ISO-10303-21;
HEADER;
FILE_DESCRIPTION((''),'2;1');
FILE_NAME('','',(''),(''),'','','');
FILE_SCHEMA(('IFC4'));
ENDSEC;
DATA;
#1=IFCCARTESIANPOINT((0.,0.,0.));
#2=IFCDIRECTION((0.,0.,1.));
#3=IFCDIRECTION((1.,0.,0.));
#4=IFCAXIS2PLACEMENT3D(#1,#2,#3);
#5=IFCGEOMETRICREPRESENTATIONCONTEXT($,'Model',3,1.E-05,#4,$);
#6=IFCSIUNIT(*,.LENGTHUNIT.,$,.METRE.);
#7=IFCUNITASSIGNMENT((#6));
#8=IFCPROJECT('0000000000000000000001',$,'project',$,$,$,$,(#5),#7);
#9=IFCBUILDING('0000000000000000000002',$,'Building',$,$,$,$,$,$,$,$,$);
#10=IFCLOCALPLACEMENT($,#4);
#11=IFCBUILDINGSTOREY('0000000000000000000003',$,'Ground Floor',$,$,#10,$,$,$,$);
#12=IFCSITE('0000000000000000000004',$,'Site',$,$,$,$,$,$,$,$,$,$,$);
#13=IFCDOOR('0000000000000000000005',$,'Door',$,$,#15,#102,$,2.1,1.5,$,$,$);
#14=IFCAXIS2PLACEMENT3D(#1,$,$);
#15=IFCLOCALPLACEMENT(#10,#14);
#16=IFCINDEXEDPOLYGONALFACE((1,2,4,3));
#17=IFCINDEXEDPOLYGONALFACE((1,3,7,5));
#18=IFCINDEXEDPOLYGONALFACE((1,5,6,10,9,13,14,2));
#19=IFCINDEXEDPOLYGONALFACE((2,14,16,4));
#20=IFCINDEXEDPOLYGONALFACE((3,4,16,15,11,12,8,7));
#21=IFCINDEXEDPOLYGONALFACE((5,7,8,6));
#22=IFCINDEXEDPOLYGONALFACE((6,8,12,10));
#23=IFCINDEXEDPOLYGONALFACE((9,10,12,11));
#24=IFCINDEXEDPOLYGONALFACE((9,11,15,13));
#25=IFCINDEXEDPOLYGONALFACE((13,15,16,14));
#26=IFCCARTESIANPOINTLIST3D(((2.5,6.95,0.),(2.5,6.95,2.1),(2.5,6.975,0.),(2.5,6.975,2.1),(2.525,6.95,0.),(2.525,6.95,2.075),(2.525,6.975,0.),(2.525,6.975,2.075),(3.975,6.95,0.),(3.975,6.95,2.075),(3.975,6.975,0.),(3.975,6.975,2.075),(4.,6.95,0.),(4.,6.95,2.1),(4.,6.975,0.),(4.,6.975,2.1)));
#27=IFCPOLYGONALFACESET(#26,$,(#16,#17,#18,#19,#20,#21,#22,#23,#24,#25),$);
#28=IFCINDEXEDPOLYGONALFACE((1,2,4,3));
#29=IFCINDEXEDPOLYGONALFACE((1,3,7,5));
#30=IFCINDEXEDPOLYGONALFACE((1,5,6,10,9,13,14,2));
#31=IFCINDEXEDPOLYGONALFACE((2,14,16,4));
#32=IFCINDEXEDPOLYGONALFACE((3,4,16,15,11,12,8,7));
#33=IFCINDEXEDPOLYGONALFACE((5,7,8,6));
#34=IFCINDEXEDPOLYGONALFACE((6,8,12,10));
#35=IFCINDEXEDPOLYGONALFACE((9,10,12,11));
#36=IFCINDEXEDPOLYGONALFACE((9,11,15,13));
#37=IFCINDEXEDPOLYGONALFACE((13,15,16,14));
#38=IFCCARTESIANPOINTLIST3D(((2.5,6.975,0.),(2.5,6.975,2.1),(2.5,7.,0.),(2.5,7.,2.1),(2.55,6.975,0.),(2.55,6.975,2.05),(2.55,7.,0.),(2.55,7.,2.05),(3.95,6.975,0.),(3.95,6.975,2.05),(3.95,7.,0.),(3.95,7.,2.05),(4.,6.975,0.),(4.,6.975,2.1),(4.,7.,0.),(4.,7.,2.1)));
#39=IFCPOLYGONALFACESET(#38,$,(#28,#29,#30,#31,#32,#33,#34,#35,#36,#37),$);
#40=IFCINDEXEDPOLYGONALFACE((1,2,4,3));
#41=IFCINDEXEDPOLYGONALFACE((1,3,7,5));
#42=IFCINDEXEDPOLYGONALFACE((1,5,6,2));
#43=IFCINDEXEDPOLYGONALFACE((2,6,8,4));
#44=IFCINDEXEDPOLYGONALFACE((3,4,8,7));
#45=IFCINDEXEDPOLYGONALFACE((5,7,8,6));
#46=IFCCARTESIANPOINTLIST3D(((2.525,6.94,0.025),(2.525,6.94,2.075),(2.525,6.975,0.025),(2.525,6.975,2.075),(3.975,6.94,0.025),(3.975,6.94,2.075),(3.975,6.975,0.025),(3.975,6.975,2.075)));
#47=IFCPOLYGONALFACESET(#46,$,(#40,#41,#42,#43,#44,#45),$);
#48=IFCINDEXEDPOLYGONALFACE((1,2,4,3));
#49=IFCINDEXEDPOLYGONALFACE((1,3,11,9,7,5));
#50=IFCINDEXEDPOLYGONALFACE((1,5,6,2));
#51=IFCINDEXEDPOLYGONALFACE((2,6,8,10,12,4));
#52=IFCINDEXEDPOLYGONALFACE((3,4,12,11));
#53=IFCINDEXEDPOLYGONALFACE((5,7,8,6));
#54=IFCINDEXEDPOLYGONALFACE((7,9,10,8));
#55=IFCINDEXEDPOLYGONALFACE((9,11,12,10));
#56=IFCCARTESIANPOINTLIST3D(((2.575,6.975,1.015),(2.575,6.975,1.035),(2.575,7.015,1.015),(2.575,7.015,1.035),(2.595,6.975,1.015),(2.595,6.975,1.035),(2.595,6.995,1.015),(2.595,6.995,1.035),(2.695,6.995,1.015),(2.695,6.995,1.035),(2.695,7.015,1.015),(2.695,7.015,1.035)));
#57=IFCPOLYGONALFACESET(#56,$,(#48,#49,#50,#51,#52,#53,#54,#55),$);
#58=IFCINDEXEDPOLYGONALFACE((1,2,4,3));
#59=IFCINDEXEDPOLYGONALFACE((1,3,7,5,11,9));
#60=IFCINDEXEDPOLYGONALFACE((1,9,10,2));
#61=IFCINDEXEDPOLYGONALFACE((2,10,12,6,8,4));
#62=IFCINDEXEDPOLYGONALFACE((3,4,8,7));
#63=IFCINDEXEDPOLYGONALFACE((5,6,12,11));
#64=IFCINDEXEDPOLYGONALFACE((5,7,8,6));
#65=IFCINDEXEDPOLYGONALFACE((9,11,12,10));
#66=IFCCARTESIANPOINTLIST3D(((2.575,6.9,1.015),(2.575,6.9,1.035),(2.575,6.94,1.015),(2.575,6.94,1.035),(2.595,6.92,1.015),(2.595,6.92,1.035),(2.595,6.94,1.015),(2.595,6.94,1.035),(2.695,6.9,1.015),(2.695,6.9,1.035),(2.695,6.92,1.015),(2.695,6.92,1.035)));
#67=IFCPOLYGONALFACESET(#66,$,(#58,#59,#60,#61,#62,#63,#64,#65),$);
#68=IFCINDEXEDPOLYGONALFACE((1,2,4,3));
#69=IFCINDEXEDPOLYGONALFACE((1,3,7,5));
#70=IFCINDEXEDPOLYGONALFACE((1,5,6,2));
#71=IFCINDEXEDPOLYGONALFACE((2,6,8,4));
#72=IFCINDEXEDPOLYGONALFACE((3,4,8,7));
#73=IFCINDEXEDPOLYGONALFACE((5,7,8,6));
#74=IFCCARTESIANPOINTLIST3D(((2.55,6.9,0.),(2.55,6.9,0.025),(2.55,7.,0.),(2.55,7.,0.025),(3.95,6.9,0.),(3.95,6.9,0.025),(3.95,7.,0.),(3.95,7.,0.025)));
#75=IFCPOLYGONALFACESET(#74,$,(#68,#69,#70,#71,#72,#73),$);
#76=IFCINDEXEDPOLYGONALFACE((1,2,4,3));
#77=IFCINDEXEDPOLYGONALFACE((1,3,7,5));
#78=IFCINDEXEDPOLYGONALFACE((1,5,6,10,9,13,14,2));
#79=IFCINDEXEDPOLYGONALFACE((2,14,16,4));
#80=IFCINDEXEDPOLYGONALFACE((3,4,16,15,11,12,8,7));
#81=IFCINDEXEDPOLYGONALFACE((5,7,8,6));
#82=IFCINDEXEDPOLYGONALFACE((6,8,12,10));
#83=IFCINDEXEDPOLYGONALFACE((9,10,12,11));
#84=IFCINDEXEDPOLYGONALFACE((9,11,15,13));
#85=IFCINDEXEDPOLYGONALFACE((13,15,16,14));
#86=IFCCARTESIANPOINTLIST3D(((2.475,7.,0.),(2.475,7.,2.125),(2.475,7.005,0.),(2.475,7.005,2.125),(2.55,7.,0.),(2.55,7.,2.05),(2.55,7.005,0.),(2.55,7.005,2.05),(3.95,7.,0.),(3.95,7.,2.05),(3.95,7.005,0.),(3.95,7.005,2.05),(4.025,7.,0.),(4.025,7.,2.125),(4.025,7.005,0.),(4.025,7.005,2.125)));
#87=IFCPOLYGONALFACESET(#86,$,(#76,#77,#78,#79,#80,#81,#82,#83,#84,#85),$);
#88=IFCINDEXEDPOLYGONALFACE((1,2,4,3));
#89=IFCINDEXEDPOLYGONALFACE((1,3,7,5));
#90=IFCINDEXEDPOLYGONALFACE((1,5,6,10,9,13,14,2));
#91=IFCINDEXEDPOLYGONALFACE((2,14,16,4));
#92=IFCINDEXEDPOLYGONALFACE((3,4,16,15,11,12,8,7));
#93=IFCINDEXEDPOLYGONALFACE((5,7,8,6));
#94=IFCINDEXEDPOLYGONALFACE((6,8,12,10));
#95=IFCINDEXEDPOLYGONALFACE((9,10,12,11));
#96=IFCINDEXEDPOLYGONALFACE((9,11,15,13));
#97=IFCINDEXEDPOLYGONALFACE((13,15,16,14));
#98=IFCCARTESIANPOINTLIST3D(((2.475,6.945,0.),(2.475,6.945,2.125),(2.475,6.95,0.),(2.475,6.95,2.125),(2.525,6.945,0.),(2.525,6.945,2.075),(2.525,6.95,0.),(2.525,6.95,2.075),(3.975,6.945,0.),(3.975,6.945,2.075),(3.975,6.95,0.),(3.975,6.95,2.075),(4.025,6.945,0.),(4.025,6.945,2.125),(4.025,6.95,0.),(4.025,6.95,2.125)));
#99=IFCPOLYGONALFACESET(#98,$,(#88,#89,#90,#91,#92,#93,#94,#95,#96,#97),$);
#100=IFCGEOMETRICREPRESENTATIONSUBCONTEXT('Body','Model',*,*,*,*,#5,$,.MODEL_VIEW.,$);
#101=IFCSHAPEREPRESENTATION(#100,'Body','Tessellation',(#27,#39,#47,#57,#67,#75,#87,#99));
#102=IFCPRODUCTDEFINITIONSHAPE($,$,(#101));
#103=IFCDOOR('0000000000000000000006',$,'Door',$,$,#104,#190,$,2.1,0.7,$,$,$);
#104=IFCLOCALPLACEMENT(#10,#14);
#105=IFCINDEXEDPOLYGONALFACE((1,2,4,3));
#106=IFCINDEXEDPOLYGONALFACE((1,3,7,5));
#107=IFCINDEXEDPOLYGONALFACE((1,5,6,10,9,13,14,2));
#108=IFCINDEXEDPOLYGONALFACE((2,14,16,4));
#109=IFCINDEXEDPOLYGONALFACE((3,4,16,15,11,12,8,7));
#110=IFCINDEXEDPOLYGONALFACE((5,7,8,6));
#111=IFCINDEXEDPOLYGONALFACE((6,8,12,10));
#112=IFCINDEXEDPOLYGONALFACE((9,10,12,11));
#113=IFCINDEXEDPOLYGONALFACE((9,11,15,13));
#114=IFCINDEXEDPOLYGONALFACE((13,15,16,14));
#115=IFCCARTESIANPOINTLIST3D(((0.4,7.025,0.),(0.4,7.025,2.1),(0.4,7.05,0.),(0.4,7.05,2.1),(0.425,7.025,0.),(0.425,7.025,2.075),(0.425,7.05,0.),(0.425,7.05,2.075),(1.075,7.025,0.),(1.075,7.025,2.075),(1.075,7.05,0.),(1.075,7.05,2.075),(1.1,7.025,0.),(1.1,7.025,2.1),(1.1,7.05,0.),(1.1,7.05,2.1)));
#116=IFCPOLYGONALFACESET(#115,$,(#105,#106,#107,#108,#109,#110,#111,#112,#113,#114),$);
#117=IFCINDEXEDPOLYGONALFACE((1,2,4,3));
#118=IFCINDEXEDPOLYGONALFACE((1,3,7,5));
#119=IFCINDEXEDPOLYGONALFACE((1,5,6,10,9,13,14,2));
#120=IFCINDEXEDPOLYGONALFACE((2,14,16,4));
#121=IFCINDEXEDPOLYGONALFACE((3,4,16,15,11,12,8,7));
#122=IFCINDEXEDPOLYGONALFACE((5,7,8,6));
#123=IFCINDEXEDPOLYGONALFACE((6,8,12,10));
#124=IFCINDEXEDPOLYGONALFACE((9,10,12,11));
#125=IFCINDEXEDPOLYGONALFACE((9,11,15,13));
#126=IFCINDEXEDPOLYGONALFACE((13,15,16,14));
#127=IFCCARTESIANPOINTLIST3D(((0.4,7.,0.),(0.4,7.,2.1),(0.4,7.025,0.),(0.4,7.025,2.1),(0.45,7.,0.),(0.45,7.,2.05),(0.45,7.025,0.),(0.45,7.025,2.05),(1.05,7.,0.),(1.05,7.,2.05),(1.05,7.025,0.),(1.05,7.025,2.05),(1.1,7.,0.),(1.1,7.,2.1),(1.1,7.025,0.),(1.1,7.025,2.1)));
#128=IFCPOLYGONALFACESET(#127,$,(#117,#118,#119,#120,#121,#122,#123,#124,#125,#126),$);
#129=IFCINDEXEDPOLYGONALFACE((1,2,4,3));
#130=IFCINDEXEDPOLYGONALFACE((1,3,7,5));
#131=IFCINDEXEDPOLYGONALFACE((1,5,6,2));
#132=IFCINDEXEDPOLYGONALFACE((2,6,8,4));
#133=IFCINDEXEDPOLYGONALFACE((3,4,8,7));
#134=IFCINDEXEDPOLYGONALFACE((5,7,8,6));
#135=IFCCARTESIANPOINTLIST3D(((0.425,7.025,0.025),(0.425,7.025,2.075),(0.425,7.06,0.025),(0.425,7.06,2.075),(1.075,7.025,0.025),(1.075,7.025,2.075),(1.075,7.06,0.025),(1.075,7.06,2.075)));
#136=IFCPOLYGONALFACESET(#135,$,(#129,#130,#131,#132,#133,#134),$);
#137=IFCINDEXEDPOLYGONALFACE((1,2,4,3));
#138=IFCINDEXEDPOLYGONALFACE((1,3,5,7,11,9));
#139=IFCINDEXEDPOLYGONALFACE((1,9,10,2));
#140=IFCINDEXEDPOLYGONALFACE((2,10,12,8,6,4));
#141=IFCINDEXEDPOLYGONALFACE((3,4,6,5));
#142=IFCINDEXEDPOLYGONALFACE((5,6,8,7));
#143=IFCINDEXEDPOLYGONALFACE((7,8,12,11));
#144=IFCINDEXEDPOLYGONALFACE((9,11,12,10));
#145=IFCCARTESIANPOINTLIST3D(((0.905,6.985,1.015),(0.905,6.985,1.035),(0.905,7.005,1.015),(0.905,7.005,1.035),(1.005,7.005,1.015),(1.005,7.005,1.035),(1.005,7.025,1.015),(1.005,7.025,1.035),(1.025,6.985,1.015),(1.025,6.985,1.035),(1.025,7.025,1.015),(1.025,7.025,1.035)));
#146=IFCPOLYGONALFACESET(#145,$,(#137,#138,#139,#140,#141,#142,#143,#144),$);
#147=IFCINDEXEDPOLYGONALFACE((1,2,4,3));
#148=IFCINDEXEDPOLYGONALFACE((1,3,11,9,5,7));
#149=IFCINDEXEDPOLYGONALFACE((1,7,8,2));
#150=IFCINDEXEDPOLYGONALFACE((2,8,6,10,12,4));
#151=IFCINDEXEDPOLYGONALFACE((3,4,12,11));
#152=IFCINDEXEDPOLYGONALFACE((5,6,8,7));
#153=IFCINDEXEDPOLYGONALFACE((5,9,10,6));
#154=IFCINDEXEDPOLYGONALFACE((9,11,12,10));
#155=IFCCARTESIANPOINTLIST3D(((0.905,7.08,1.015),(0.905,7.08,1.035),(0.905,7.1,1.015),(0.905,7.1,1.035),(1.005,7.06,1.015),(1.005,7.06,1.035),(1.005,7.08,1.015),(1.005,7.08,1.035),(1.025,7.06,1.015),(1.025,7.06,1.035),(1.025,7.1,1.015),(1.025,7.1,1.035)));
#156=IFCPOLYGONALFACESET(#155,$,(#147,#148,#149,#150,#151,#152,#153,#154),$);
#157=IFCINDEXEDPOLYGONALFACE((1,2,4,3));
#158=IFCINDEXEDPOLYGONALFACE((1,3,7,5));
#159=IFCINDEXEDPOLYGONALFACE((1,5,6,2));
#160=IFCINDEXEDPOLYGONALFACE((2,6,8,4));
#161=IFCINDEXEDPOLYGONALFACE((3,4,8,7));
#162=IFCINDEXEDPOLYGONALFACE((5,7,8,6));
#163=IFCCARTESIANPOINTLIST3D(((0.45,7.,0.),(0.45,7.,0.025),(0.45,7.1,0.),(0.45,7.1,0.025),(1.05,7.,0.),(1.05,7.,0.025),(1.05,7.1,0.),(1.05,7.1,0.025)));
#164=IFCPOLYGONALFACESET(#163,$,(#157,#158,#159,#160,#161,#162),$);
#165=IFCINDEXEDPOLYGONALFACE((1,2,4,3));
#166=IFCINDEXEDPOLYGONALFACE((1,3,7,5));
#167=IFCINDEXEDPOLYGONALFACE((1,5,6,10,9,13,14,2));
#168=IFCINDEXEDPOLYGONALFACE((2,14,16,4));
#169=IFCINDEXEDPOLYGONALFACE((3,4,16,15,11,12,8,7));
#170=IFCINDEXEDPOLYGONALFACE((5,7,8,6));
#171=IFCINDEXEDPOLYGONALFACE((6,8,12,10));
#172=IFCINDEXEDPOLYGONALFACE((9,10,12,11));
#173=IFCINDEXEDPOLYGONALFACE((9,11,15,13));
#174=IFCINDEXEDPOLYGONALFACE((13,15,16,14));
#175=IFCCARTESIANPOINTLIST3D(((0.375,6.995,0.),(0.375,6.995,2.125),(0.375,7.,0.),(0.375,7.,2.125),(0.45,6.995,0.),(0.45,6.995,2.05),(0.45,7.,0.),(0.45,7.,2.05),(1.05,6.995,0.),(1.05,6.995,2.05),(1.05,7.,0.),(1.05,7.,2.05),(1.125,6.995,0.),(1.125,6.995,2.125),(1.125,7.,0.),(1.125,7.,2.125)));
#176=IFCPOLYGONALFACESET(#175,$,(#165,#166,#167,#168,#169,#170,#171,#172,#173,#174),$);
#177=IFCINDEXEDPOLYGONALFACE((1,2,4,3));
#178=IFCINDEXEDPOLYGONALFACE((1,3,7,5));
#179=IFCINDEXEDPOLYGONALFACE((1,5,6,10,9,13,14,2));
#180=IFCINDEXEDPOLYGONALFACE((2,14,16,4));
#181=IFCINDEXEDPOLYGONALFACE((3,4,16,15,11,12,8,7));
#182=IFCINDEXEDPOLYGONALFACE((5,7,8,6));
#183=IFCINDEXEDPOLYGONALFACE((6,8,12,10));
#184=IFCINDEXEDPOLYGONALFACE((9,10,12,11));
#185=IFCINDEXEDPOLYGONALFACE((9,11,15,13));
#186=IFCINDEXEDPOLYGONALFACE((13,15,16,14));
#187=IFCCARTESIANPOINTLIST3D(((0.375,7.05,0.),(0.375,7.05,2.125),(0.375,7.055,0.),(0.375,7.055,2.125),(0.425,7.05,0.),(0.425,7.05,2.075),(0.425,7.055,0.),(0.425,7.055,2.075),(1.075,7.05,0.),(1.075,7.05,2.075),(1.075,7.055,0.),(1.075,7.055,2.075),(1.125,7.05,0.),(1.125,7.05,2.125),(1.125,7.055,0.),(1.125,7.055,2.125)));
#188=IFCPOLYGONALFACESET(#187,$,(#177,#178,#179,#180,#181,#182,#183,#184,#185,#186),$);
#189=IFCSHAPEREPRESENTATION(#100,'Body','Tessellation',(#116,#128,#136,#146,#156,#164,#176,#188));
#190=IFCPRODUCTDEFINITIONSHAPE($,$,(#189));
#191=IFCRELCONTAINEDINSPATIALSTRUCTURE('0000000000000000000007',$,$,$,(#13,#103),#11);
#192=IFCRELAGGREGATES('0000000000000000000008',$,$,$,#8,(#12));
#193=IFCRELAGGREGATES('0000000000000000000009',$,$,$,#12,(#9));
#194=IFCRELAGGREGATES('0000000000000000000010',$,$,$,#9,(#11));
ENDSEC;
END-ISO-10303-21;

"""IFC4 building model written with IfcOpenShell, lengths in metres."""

from ifc_helpers import new_model, si_unit, frame, origin_with_axes, place, context, subcontext, project, spatial, line, indexed_curve, outline, extrude, element, save


model = new_model("IFC4")

# Units and contexts
model_context = context("Model", 3, precision=1e-05, world=origin_with_axes())
body_context = subcontext(model_context, "Body", "Model", "MODEL_VIEW")
ifc_project = project(units=[si_unit("LENGTHUNIT", "METRE")], contexts=[model_context])

# Site, building, storey
site = spatial("IfcSite", under=ifc_project, Name="Site")
building = spatial("IfcBuilding", under=site, Name="Building")
storey_placement = place(None, origin_with_axes())
storey = spatial("IfcBuildingStorey", under=building, at=storey_placement, Name="Ground Floor")

# Doors
door_1_placement = place(storey_placement, frame((4.0, 7.0, 0.0), z_axis=(0.0, 0.0, 1.0), x_axis=(-1.0, 0.0, 0.0)))
element("IfcDoor", 1, at=door_1_placement, inside=storey, Name="Door", OverallHeight=2.1, OverallWidth=1.5, context=body_context, shape_type="SweptSolid", body=[
    extrude(outline(indexed_curve([(0.0, 0.0), (0.0, 2.1), (1.5, 2.1), (1.5, 0.0), (1.475, 0.0), (1.475, 2.075), (0.025, 2.075), (0.025, 0.0)], segments=[line(1, 2, 3, 4, 5, 6, 7, 8, 1)])), frame((0.0, 0.025, 0.0), z_axis=(0.0, -1.0, 0.0), x_axis=(1.0, 0.0, 0.0)), (0.0, 0.0, -1.0), 0.025),
    extrude(outline(indexed_curve([(0.0, 0.0), (0.0, 2.1), (1.5, 2.1), (1.5, 0.0), (1.45, 0.0), (1.45, 2.05), (0.05, 2.05), (0.05, 0.0)], segments=[line(1, 2, 3, 4, 5, 6, 7, 8, 1)])), frame((0.0, 0.0, 0.0), z_axis=(0.0, -1.0, 0.0), x_axis=(1.0, 0.0, 0.0)), (0.0, 0.0, -1.0), 0.025),
    extrude(outline(indexed_curve([(0.0, 0.0), (1.45, 0.0), (1.45, 0.035), (0.0, 0.035)], segments=[line(1, 2, 3, 4, 1)])), frame((0.025, 0.025, 0.025), z_axis=(0.0, 0.0, 1.0), x_axis=(1.0, 0.0, 0.0)), (0.0, 0.0, 1.0), 2.05),
    extrude(outline(indexed_curve([(0.0, 0.0), (0.0, -0.04), (-0.12, -0.04), (-0.12, -0.02), (-0.02, -0.02), (-0.02, 0.0)], segments=[line(1, 2, 3, 4, 5, 6, 1)])), frame((1.425, 0.025, 1.015), z_axis=(0.0, 0.0, 1.0), x_axis=(1.0, 0.0, 0.0)), (0.0, 0.0, 1.0), 0.02),
    extrude(outline(indexed_curve([(0.0, 0.0), (0.0, 0.04), (-0.12, 0.04), (-0.12, 0.02), (-0.02, 0.02), (-0.02, 0.0)], segments=[line(1, 2, 3, 4, 5, 6, 1)])), frame((1.425, 0.06, 1.015), z_axis=(0.0, 0.0, 1.0), x_axis=(1.0, 0.0, 0.0)), (0.0, 0.0, 1.0), 0.02),
    extrude(outline(indexed_curve([(0.0, 0.0), (1.4, 0.0), (1.4, 0.1), (0.0, 0.1)], segments=[line(1, 2, 3, 4, 1)])), frame((0.05, 0.0, 0.0), z_axis=(0.0, 0.0, 1.0), x_axis=(1.0, 0.0, 0.0)), (0.0, 0.0, 1.0), 0.025),
    extrude(outline(indexed_curve([(0.0, 0.0), (0.0, 2.125), (1.55, 2.125), (1.55, 0.0), (1.475, 0.0), (1.475, 2.05), (0.075, 2.05), (0.075, 0.0)], segments=[line(1, 2, 3, 4, 5, 6, 7, 8, 1)])), frame((-0.025, -0.005, 0.0), z_axis=(0.0, -1.0, 0.0), x_axis=(1.0, 0.0, 0.0)), (0.0, 0.0, -1.0), 0.005),
    extrude(outline(indexed_curve([(0.0, 0.0), (0.0, 2.125), (1.55, 2.125), (1.55, 0.0), (1.5, 0.0), (1.5, 2.075), (0.05, 2.075), (0.05, 0.0)], segments=[line(1, 2, 3, 4, 5, 6, 7, 8, 1)])), frame((-0.025, 0.05, 0.0), z_axis=(0.0, -1.0, 0.0), x_axis=(1.0, 0.0, 0.0)), (0.0, 0.0, -1.0), 0.005),
])
door_2_placement = place(storey_placement, frame((0.4, 7.0, 0.0), z_axis=(0.0, 0.0, 1.0), x_axis=(1.0, 0.0, 0.0)))
element("IfcDoor", 2, at=door_2_placement, inside=storey, Name="Door", OverallHeight=2.1, OverallWidth=0.7, context=body_context, shape_type="SweptSolid", body=[
    extrude(outline(indexed_curve([(0.0, 0.0), (0.0, 2.1), (0.7, 2.1), (0.7, 0.0), (0.675, 0.0), (0.675, 2.075), (0.025, 2.075), (0.025, 0.0)], segments=[line(1, 2, 3, 4, 5, 6, 7, 8, 1)])), frame((0.0, 0.025, 0.0), z_axis=(0.0, -1.0, 0.0), x_axis=(1.0, 0.0, 0.0)), (0.0, 0.0, -1.0), 0.025),
    extrude(outline(indexed_curve([(0.0, 0.0), (0.0, 2.1), (0.7, 2.1), (0.7, 0.0), (0.65, 0.0), (0.65, 2.05), (0.05, 2.05), (0.05, 0.0)], segments=[line(1, 2, 3, 4, 5, 6, 7, 8, 1)])), frame((0.0, 0.0, 0.0), z_axis=(0.0, -1.0, 0.0), x_axis=(1.0, 0.0, 0.0)), (0.0, 0.0, -1.0), 0.025),
    extrude(outline(indexed_curve([(0.0, 0.0), (0.65, 0.0), (0.65, 0.035), (0.0, 0.035)], segments=[line(1, 2, 3, 4, 1)])), frame((0.025, 0.025, 0.025), z_axis=(0.0, 0.0, 1.0), x_axis=(1.0, 0.0, 0.0)), (0.0, 0.0, 1.0), 2.05),
    extrude(outline(indexed_curve([(0.0, 0.0), (0.0, -0.04), (-0.12, -0.04), (-0.12, -0.02), (-0.02, -0.02), (-0.02, 0.0)], segments=[line(1, 2, 3, 4, 5, 6, 1)])), frame((0.625, 0.025, 1.015), z_axis=(0.0, 0.0, 1.0), x_axis=(1.0, 0.0, 0.0)), (0.0, 0.0, 1.0), 0.02),
    extrude(outline(indexed_curve([(0.0, 0.0), (0.0, 0.04), (-0.12, 0.04), (-0.12, 0.02), (-0.02, 0.02), (-0.02, 0.0)], segments=[line(1, 2, 3, 4, 5, 6, 1)])), frame((0.625, 0.06, 1.015), z_axis=(0.0, 0.0, 1.0), x_axis=(1.0, 0.0, 0.0)), (0.0, 0.0, 1.0), 0.02),
    extrude(outline(indexed_curve([(0.0, 0.0), (0.6, 0.0), (0.6, 0.1), (0.0, 0.1)], segments=[line(1, 2, 3, 4, 1)])), frame((0.05, 0.0, 0.0), z_axis=(0.0, 0.0, 1.0), x_axis=(1.0, 0.0, 0.0)), (0.0, 0.0, 1.0), 0.025),
    extrude(outline(indexed_curve([(0.0, 0.0), (0.0, 2.125), (0.75, 2.125), (0.75, 0.0), (0.675, 0.0), (0.675, 2.05), (0.075, 2.05), (0.075, 0.0)], segments=[line(1, 2, 3, 4, 5, 6, 7, 8, 1)])), frame((-0.025, -0.005, 0.0), z_axis=(0.0, -1.0, 0.0), x_axis=(1.0, 0.0, 0.0)), (0.0, 0.0, -1.0), 0.005),
    extrude(outline(indexed_curve([(0.0, 0.0), (0.0, 2.125), (0.75, 2.125), (0.75, 0.0), (0.7, 0.0), (0.7, 2.075), (0.05, 2.075), (0.05, 0.0)], segments=[line(1, 2, 3, 4, 5, 6, 7, 8, 1)])), frame((-0.025, 0.05, 0.0), z_axis=(0.0, -1.0, 0.0), x_axis=(1.0, 0.0, 0.0)), (0.0, 0.0, -1.0), 0.005),
])

save(model, "model.ifc")
